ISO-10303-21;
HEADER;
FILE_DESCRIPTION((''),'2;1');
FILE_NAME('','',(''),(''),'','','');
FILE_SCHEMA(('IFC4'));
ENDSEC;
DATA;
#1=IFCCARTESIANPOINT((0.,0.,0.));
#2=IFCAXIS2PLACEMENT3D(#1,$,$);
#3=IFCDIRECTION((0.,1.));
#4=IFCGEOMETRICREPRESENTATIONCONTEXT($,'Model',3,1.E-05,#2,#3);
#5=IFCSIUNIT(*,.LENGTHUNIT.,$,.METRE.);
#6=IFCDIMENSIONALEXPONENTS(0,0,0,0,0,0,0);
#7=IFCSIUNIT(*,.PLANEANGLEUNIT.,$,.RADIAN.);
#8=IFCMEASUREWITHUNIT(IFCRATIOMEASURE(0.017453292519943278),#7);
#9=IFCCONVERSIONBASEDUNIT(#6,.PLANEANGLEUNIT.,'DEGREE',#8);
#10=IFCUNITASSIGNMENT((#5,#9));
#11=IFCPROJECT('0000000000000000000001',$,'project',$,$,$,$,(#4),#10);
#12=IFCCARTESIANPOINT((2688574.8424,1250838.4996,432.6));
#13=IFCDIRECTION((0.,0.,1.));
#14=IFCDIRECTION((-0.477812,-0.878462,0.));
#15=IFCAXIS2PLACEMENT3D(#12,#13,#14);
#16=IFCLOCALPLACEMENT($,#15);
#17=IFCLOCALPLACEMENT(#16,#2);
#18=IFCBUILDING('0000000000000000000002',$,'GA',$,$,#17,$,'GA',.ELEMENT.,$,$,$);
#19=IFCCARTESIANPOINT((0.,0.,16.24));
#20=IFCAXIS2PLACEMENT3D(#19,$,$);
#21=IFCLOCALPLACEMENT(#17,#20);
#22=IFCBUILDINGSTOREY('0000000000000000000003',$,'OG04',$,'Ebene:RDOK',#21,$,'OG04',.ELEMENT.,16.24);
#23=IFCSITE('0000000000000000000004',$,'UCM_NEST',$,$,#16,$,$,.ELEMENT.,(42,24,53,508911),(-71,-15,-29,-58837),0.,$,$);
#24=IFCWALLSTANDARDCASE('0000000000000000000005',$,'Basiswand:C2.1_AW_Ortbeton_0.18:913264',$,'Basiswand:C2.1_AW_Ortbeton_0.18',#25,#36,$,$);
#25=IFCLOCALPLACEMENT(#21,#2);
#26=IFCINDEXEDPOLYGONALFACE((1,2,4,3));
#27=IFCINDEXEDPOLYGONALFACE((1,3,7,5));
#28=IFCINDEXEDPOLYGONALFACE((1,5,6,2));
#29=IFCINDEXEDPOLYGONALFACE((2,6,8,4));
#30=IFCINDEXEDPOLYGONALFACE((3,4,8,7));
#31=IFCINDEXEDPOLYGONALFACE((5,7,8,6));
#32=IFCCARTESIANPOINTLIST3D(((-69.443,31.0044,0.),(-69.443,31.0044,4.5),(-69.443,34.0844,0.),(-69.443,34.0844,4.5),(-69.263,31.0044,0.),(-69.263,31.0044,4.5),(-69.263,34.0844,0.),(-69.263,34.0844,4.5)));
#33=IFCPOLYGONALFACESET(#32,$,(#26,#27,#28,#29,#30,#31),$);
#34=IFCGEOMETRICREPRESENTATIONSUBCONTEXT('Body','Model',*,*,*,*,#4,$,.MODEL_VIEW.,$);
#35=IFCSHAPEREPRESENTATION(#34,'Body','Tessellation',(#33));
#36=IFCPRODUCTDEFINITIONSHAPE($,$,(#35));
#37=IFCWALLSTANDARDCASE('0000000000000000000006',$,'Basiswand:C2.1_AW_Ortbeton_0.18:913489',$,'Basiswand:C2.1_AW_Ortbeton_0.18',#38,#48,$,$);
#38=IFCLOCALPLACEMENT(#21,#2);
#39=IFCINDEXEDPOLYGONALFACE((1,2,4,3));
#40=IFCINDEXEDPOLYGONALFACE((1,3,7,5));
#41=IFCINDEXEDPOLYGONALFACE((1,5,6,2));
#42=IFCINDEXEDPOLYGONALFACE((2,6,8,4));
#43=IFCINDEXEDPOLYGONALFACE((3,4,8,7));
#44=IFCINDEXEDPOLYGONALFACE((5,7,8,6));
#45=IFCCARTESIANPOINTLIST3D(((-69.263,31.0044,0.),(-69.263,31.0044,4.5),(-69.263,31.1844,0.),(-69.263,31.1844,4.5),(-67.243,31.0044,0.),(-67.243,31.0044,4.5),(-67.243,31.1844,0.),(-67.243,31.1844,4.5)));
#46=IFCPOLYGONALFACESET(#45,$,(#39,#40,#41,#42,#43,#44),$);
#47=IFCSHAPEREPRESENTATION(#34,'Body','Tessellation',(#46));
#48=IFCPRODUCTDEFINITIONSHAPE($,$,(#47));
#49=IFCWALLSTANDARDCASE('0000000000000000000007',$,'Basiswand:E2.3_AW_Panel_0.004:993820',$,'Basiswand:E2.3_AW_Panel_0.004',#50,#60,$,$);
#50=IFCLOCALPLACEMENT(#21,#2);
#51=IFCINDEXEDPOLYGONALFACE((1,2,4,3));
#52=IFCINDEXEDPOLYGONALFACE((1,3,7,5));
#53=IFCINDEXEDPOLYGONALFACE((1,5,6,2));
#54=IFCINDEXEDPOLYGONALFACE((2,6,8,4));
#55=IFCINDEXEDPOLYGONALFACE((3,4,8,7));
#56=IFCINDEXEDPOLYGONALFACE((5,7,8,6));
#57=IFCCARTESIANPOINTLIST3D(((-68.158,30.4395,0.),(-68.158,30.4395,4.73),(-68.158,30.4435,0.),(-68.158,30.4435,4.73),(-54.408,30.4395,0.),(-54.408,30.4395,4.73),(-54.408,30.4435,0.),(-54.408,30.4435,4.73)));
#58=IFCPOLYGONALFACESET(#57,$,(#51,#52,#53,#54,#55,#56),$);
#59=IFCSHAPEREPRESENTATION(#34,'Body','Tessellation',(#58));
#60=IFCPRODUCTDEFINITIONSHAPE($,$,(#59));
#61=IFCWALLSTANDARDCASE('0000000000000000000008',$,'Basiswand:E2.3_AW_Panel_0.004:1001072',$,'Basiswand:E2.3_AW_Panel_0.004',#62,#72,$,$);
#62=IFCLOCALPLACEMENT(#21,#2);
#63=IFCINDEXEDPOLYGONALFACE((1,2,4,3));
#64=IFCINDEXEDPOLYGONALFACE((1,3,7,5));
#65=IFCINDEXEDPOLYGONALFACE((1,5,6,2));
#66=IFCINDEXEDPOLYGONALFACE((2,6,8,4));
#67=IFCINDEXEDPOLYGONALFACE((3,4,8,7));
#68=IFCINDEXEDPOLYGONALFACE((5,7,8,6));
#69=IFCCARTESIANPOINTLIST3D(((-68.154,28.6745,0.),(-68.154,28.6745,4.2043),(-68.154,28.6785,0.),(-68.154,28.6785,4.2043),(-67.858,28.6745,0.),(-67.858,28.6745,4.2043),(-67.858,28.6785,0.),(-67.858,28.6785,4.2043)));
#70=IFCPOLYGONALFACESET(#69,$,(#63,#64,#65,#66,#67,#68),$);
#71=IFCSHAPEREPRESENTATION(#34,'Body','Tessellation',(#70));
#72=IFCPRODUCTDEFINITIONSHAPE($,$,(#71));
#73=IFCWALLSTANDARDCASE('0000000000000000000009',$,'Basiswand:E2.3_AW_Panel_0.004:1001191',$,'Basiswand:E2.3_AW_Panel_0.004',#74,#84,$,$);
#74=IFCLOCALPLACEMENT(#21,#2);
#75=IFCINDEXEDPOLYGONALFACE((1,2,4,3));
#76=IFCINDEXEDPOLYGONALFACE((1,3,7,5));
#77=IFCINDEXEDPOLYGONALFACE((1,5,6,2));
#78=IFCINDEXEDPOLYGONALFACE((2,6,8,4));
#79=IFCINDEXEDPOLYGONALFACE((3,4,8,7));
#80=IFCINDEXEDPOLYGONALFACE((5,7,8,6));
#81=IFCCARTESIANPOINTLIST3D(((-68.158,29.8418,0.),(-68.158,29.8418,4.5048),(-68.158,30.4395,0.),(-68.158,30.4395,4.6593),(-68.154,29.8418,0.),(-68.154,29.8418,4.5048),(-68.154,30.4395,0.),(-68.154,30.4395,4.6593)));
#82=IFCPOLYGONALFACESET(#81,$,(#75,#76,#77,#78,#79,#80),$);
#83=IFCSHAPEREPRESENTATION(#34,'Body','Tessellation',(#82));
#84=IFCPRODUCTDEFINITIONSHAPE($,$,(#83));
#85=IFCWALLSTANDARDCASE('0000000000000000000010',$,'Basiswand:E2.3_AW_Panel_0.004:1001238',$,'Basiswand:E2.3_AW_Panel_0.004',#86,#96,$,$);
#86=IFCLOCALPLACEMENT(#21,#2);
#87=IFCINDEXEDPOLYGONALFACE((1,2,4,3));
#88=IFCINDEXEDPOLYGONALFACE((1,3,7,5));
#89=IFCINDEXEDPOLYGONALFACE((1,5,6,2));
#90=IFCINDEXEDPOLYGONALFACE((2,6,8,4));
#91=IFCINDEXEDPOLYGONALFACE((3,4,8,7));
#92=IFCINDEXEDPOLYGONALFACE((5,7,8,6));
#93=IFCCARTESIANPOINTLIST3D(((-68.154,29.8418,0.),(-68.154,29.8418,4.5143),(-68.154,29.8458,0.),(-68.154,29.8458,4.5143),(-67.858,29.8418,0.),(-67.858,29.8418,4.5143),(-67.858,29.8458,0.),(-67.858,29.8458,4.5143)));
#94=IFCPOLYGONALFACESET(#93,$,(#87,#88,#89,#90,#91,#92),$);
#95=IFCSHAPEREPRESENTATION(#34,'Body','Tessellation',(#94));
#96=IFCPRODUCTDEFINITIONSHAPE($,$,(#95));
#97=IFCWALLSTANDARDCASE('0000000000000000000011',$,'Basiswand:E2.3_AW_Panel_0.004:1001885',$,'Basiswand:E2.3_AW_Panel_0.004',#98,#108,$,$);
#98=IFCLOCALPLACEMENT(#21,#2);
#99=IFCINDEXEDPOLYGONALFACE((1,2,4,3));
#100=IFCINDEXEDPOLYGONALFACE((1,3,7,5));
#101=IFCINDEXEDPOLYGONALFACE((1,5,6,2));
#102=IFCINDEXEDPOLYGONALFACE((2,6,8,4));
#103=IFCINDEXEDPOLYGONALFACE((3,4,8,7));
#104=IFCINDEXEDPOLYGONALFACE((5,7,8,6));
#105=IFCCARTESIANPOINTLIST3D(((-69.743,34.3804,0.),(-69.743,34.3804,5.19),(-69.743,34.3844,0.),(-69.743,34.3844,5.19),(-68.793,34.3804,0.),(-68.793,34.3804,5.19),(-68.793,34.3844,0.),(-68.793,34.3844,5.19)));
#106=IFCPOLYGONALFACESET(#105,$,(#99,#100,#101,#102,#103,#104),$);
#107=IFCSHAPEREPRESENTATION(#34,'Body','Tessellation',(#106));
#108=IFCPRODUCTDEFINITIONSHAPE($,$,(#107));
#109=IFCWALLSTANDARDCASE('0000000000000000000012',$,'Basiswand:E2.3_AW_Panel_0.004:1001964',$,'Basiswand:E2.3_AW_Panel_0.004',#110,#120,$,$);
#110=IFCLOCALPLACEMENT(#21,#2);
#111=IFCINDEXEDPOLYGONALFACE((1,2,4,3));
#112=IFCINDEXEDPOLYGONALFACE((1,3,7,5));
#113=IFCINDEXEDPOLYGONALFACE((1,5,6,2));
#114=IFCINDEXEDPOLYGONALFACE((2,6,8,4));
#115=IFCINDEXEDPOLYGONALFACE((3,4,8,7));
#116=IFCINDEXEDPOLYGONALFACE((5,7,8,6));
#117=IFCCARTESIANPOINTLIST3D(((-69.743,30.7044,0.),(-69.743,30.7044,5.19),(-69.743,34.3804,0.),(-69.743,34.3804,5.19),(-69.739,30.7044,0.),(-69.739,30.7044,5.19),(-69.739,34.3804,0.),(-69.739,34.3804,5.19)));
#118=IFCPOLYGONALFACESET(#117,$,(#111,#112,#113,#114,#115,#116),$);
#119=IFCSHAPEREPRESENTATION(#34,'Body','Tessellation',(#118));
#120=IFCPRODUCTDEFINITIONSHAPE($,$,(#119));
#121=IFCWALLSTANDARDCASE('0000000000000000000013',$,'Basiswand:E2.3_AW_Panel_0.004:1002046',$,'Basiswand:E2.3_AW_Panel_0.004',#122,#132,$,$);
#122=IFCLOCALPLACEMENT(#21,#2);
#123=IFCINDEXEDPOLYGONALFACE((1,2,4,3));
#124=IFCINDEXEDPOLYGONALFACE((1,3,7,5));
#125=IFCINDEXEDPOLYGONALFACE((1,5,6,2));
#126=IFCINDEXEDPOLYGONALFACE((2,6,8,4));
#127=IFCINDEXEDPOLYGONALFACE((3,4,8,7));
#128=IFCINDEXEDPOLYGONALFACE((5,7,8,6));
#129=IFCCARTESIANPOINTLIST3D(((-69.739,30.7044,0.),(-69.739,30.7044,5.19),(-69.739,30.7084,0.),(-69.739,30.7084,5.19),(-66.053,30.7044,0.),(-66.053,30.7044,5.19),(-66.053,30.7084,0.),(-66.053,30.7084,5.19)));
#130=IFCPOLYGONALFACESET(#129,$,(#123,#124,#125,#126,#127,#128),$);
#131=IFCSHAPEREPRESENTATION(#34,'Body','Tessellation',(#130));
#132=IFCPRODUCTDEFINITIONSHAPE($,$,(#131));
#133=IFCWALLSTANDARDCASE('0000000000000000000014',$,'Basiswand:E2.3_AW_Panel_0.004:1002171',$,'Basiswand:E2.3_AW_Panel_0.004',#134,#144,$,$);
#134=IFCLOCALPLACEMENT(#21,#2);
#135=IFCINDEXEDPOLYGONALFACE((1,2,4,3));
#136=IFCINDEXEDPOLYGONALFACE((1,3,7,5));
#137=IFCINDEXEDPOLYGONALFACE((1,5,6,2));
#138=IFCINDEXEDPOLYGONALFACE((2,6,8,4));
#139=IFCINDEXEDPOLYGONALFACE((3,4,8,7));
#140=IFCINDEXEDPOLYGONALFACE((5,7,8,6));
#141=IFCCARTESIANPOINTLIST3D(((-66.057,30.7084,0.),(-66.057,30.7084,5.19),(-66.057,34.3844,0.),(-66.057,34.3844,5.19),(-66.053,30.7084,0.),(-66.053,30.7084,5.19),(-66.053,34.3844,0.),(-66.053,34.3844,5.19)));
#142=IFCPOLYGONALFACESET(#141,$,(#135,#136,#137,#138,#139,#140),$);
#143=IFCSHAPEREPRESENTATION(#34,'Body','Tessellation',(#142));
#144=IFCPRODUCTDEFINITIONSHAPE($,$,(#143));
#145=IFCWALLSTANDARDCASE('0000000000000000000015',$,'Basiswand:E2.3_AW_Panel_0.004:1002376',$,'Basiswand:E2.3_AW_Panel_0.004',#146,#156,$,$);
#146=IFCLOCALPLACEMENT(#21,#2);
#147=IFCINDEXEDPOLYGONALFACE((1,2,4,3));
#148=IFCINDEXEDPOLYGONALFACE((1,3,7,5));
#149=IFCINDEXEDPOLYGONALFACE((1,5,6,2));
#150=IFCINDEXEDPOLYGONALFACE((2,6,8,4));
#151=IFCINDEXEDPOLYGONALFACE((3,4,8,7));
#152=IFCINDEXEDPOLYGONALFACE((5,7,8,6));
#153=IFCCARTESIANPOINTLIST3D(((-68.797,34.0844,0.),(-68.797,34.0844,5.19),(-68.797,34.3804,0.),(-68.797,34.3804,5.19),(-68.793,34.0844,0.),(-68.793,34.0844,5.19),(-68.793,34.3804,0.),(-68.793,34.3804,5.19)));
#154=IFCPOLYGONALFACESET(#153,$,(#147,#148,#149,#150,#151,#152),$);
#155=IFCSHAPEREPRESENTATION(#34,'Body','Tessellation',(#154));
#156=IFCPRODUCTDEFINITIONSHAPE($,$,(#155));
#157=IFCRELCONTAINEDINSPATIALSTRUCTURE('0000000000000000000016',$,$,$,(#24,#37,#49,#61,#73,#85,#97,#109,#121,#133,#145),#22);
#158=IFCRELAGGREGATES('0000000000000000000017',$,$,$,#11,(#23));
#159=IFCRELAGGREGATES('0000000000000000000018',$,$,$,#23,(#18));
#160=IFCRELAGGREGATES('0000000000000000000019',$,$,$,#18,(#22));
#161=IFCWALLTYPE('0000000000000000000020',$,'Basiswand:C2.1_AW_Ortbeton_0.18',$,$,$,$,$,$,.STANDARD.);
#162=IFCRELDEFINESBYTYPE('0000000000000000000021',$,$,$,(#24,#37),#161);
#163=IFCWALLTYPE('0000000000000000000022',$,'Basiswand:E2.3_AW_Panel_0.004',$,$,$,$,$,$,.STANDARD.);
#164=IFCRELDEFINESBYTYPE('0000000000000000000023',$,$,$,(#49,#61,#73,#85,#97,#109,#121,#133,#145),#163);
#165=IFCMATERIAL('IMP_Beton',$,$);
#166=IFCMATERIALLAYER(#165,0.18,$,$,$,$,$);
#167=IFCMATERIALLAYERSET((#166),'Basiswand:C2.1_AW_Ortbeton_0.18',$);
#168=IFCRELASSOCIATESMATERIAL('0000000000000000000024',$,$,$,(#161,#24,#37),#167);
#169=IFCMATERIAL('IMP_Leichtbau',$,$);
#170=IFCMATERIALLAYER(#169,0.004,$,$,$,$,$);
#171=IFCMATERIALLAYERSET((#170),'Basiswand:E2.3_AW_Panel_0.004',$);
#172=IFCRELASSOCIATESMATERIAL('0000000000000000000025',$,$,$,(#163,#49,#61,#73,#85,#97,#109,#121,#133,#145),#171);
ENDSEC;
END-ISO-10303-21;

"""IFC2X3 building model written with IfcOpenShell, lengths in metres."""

from ifc_helpers import new_model, entity, si_unit, converted_unit, direction, frame, frame_2d, origin, place, context, subcontext, project, spatial, rectangle, extrude, clip, halfspace, material, layer, layer_set, layer_usage, type_object, element, save


model = new_model("IFC2X3")

# Units and contexts
model_context = context("Model", 3, precision=1e-05, world=origin(), true_north=direction((0.0, 1.0)))
body_context = subcontext(model_context, "Body", "Model", "MODEL_VIEW")
ifc_project = project(units=[si_unit("LENGTHUNIT", "METRE"), converted_unit("PLANEANGLEUNIT", "DEGREE", entity("IfcRatioMeasure", 0.017453292519943278), si_unit("PLANEANGLEUNIT", "RADIAN"), dimensions=[0, 0, 0, 0, 0, 0, 0])], contexts=[model_context])

# Site, building, storey
site_placement = place(None, frame((2688574.8424, 1250838.4996, 432.6), z_axis=(0.0, 0.0, 1.0), x_axis=(-0.477812, -0.878462, 0.0)))
site = spatial("IfcSite", under=ifc_project, at=site_placement, Name="UCM_NEST", CompositionType="ELEMENT", RefLatitude=(42, 24, 53, 508911), RefLongitude=(-71, -15, -29, -58837), RefElevation=0.0)
building_placement = place(site_placement, origin())
building = spatial("IfcBuilding", under=site, at=building_placement, Name="GA", LongName="GA", CompositionType="ELEMENT")
storey_placement = place(building_placement, frame((0.0, 0.0, 16.24)))
storey = spatial("IfcBuildingStorey", under=building, at=storey_placement, Name="OG04", ObjectType="Ebene:RDOK", LongName="OG04", CompositionType="ELEMENT", Elevation=16.24)

# Shared definitions
ifc_material_1 = material(Name="IMP_Beton")

# Walls
ifc_layer_1 = layer(ifc_material_1, 0.18)
ifc_layer_set_1 = layer_set([ifc_layer_1], Name="Basiswand:C2.1_AW_Ortbeton_0.18")
ifc_layer_usage_1 = layer_usage(ifc_layer_set_1, "AXIS2", "NEGATIVE", 0.09)
wall_type_1 = type_object("IfcWallType", Name="Basiswand:C2.1_AW_Ortbeton_0.18", PredefinedType="STANDARD", material=ifc_layer_set_1)
wall_1_placement = place(storey_placement, frame((-69.353, 31.0044, 0.0), z_axis=(0.0, 0.0, 1.0), x_axis=(0.0, 1.0, 0.0)))
element("IfcWallStandardCase", 1, at=wall_1_placement, inside=storey, type_object=wall_type_1, material=ifc_layer_usage_1, Name="Basiswand:C2.1_AW_Ortbeton_0.18:913264", ObjectType="Basiswand:C2.1_AW_Ortbeton_0.18", context=body_context, shape_type="SweptSolid", body=[
    extrude(rectangle(XDim=3.08, YDim=0.18, at=frame_2d((1.54, 0.0), x_axis=(-1.0, 0.0))), origin(), (0.0, 0.0, 1.0), 4.5),
])
wall_2_placement = place(storey_placement, frame((-67.243, 31.0944, 0.0), z_axis=(0.0, 0.0, 1.0), x_axis=(-1.0, 0.0, 0.0)))
element("IfcWallStandardCase", 2, at=wall_2_placement, inside=storey, type_object=wall_type_1, material=ifc_layer_usage_1, Name="Basiswand:C2.1_AW_Ortbeton_0.18:913489", ObjectType="Basiswand:C2.1_AW_Ortbeton_0.18", context=body_context, shape_type="SweptSolid", body=[
    extrude(rectangle(XDim=2.02, YDim=0.18, at=frame_2d((1.01, 0.0), x_axis=(-1.0, 0.0))), origin(), (0.0, 0.0, 1.0), 4.5),
])
ifc_material_2 = material(Name="IMP_Leichtbau")
ifc_layer_2 = layer(ifc_material_2, 0.004)
ifc_layer_set_2 = layer_set([ifc_layer_2], Name="Basiswand:E2.3_AW_Panel_0.004")
ifc_layer_usage_2 = layer_usage(ifc_layer_set_2, "AXIS2", "NEGATIVE", 0.002)
wall_type_2 = type_object("IfcWallType", Name="Basiswand:E2.3_AW_Panel_0.004", PredefinedType="STANDARD", material=ifc_layer_set_2)
wall_3_placement = place(storey_placement, frame((-68.158, 30.4415, 0.0)))
element("IfcWallStandardCase", 3, at=wall_3_placement, inside=storey, type_object=wall_type_2, material=ifc_layer_usage_2, Name="Basiswand:E2.3_AW_Panel_0.004:993820", ObjectType="Basiswand:E2.3_AW_Panel_0.004", context=body_context, shape_type="SweptSolid", body=[
    extrude(rectangle(XDim=13.75, YDim=0.004, at=frame_2d((6.875, 0.0), x_axis=(-1.0, 0.0))), origin(), (0.0, 0.0, 1.0), 4.73),
])
wall_4_placement = place(storey_placement, frame((-68.154, 28.6765, 0.0)))
element("IfcWallStandardCase", 4, at=wall_4_placement, inside=storey, type_object=wall_type_2, material=ifc_layer_usage_2, Name="Basiswand:E2.3_AW_Panel_0.004:1001072", ObjectType="Basiswand:E2.3_AW_Panel_0.004", context=body_context, shape_type="SweptSolid", body=[
    extrude(rectangle(XDim=0.296, YDim=0.004, at=frame_2d((0.148, 0.0), x_axis=(-1.0, 0.0))), origin(), (0.0, 0.0, 1.0), 4.2043),
])
wall_5_placement = place(storey_placement, frame((-68.156, 30.4395, 0.0), z_axis=(0.0, 0.0, 1.0), x_axis=(0.0, -1.0, 0.0)))
element("IfcWallStandardCase", 5, at=wall_5_placement, inside=storey, type_object=wall_type_2, material=ifc_layer_usage_2, Name="Basiswand:E2.3_AW_Panel_0.004:1001191", ObjectType="Basiswand:E2.3_AW_Panel_0.004", context=body_context, shape_type="Clipping", body=[
    clip(extrude(rectangle(XDim=0.5977, YDim=0.004, at=frame_2d((0.2988, 0.0), x_axis=(-1.0, 0.0))), origin(), (0.0, 0.0, 1.0), 4.6593), halfspace(frame((0.0, -0.002, 4.6593), z_axis=(0.250322, 0.0, 0.968163), x_axis=(0.0, 1.0, 0.0)), False)),
])
wall_6_placement = place(storey_placement, frame((-68.154, 29.8438, 0.0)))
element("IfcWallStandardCase", 6, at=wall_6_placement, inside=storey, type_object=wall_type_2, material=ifc_layer_usage_2, Name="Basiswand:E2.3_AW_Panel_0.004:1001238", ObjectType="Basiswand:E2.3_AW_Panel_0.004", context=body_context, shape_type="SweptSolid", body=[
    extrude(rectangle(XDim=0.296, YDim=0.004, at=frame_2d((0.148, 0.0), x_axis=(-1.0, 0.0))), origin(), (0.0, 0.0, 1.0), 4.5143),
])
wall_7_placement = place(storey_placement, frame((-68.793, 34.3824, 0.0), z_axis=(0.0, 0.0, 1.0), x_axis=(-1.0, 0.0, 0.0)))
element("IfcWallStandardCase", 7, at=wall_7_placement, inside=storey, type_object=wall_type_2, material=ifc_layer_usage_2, Name="Basiswand:E2.3_AW_Panel_0.004:1001885", ObjectType="Basiswand:E2.3_AW_Panel_0.004", context=body_context, shape_type="SweptSolid", body=[
    extrude(rectangle(XDim=0.95, YDim=0.004, at=frame_2d((0.475, 0.0), x_axis=(-1.0, 0.0))), origin(), (0.0, 0.0, 1.0), 5.19),
])
wall_8_placement = place(storey_placement, frame((-69.741, 34.3804, 0.0), z_axis=(0.0, 0.0, 1.0), x_axis=(0.0, -1.0, 0.0)))
element("IfcWallStandardCase", 8, at=wall_8_placement, inside=storey, type_object=wall_type_2, material=ifc_layer_usage_2, Name="Basiswand:E2.3_AW_Panel_0.004:1001964", ObjectType="Basiswand:E2.3_AW_Panel_0.004", context=body_context, shape_type="SweptSolid", body=[
    extrude(rectangle(XDim=3.676, YDim=0.004, at=frame_2d((1.838, 0.0), x_axis=(-1.0, 0.0))), origin(), (0.0, 0.0, 1.0), 5.19),
])
wall_9_placement = place(storey_placement, frame((-69.739, 30.7064, 0.0)))
element("IfcWallStandardCase", 9, at=wall_9_placement, inside=storey, type_object=wall_type_2, material=ifc_layer_usage_2, Name="Basiswand:E2.3_AW_Panel_0.004:1002046", ObjectType="Basiswand:E2.3_AW_Panel_0.004", context=body_context, shape_type="SweptSolid", body=[
    extrude(rectangle(XDim=3.686, YDim=0.004, at=frame_2d((1.843, 0.0), x_axis=(-1.0, 0.0))), origin(), (0.0, 0.0, 1.0), 5.19),
])
wall_10_placement = place(storey_placement, frame((-66.055, 30.7084, 0.0), z_axis=(0.0, 0.0, 1.0), x_axis=(0.0, 1.0, 0.0)))
element("IfcWallStandardCase", 10, at=wall_10_placement, inside=storey, type_object=wall_type_2, material=ifc_layer_usage_2, Name="Basiswand:E2.3_AW_Panel_0.004:1002171", ObjectType="Basiswand:E2.3_AW_Panel_0.004", context=body_context, shape_type="SweptSolid", body=[
    extrude(rectangle(XDim=3.676, YDim=0.004, at=frame_2d((1.838, 0.0), x_axis=(-1.0, 0.0))), origin(), (0.0, 0.0, 1.0), 5.19),
])
ifc_layer_usage_3 = layer_usage(ifc_layer_set_2, "AXIS2", "POSITIVE", -0.002)
wall_11_placement = place(storey_placement, frame((-68.795, 34.0844, 0.0), z_axis=(0.0, 0.0, 1.0), x_axis=(0.0, 1.0, 0.0)))
element("IfcWallStandardCase", 11, at=wall_11_placement, inside=storey, type_object=wall_type_2, material=ifc_layer_usage_3, Name="Basiswand:E2.3_AW_Panel_0.004:1002376", ObjectType="Basiswand:E2.3_AW_Panel_0.004", context=body_context, shape_type="SweptSolid", body=[
    extrude(rectangle(XDim=0.296, YDim=0.004, at=frame_2d((0.148, 0.0), x_axis=(-1.0, 0.0))), origin(), (0.0, 0.0, 1.0), 5.19),
])

save(model, "model.ifc")
